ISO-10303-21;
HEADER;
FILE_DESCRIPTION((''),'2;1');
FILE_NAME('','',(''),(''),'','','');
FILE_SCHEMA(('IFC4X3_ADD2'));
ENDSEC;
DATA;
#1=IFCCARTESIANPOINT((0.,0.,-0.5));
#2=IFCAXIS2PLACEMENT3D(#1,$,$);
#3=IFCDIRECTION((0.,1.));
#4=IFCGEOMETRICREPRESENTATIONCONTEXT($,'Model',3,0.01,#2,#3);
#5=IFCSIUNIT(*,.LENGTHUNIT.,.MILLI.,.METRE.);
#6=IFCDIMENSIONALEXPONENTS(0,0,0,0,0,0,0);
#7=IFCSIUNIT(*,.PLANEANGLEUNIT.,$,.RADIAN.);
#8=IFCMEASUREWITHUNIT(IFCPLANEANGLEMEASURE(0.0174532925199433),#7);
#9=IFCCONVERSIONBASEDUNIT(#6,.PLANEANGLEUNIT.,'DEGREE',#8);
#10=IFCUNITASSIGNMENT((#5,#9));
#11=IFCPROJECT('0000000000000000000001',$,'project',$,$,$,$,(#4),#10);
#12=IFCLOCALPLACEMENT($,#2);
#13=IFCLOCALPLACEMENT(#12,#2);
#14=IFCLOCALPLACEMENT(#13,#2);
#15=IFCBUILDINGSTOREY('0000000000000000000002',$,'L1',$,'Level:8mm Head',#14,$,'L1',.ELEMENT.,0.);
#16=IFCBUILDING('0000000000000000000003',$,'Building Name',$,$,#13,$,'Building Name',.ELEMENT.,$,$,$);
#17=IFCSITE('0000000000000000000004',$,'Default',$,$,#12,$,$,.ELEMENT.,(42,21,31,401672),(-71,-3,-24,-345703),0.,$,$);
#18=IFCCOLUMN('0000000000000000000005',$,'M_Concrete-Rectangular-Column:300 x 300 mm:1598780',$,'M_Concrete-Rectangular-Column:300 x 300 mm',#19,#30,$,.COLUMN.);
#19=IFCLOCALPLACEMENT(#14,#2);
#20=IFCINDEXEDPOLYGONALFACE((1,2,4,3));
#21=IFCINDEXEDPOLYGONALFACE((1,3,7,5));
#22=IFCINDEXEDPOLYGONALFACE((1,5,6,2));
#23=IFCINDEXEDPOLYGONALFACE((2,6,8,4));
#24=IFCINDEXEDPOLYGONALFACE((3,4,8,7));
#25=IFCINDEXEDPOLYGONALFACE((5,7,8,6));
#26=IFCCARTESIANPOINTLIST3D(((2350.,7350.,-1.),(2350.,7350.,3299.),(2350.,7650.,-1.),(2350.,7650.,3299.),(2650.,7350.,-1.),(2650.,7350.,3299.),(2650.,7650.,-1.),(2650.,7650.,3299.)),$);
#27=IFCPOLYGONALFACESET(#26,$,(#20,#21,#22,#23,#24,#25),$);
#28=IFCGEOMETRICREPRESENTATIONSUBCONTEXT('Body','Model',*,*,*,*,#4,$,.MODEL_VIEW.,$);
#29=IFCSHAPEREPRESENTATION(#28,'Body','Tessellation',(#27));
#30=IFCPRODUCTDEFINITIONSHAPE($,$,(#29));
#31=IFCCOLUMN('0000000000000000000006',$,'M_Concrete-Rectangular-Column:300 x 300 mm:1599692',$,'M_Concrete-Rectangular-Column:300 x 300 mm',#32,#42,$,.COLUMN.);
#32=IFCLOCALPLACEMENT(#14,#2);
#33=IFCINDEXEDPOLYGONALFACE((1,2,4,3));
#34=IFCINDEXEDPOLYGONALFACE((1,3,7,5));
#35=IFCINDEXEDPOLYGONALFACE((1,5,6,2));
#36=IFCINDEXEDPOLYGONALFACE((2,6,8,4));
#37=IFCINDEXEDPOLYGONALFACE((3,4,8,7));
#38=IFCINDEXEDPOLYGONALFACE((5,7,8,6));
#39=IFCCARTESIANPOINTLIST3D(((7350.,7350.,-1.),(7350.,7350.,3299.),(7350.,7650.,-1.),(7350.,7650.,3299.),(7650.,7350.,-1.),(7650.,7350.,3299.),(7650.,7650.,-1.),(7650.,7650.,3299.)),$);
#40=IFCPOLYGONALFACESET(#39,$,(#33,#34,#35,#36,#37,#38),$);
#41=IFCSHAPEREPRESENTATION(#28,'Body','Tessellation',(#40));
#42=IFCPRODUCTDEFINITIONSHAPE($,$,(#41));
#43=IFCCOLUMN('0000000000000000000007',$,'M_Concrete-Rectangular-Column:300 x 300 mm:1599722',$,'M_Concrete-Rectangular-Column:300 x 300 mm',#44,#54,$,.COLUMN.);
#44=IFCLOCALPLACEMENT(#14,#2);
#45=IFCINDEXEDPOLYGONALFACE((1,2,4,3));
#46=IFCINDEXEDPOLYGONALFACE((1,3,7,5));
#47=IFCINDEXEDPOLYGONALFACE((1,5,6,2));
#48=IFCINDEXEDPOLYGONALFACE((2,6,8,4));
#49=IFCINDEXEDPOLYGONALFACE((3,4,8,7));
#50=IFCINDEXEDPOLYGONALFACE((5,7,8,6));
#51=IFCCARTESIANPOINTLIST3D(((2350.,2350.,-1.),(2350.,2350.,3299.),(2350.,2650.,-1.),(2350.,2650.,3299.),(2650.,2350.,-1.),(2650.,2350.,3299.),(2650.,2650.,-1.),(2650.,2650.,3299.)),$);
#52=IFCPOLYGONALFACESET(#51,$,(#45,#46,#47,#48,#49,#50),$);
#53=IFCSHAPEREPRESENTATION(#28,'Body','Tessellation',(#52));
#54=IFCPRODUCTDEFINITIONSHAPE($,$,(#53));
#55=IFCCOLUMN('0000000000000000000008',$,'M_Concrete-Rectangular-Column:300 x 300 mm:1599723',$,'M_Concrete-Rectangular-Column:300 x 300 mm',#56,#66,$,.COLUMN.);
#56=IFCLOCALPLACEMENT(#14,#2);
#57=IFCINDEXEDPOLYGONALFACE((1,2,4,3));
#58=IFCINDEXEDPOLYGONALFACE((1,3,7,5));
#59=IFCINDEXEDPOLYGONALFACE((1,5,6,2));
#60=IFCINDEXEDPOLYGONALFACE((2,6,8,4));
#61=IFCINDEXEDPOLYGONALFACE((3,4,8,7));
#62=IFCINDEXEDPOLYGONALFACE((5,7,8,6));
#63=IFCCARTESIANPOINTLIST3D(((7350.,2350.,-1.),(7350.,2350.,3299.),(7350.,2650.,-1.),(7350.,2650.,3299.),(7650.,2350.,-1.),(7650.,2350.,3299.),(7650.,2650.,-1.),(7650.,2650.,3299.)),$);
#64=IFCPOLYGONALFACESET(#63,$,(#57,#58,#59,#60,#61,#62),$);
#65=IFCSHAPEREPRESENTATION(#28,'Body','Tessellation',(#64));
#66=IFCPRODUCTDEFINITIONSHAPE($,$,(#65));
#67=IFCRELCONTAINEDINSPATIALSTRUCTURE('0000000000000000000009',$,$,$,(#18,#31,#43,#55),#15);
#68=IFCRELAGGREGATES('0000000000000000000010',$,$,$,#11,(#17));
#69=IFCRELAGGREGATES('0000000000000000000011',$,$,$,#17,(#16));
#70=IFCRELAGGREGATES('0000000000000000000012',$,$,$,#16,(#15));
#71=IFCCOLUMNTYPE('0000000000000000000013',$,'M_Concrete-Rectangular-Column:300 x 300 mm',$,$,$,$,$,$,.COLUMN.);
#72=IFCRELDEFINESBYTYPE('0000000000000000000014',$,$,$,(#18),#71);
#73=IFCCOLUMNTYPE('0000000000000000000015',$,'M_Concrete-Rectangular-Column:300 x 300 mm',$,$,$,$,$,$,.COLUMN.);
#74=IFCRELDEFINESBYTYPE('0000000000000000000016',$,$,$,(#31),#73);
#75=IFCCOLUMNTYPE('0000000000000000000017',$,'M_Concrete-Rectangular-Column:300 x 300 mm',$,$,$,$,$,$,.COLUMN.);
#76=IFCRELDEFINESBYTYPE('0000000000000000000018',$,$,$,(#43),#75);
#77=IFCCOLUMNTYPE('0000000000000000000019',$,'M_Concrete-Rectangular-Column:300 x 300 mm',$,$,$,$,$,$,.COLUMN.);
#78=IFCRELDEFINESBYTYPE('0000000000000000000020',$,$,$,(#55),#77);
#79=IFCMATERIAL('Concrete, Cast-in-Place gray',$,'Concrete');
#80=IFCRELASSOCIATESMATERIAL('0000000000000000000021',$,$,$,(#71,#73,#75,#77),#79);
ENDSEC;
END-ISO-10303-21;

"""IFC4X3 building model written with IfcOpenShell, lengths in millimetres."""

from ifc_helpers import new_model, entity, si_unit, converted_unit, direction, frame, origin_2d_with_axis, place, context, subcontext, project, spatial, rectangle, extrude, source, transform, mapped, material, material_profile, profile_set, type_object, type_shapes, element, save


model = new_model("IFC4X3")

# Units and contexts
model_context = context("Model", 3, precision=0.01, world=frame((0.0, 0.0, -0.5)), true_north=direction((0.0, 1.0)))
body_context = subcontext(model_context, "Body", "Model", "MODEL_VIEW")
ifc_project = project(units=[si_unit("LENGTHUNIT", "METRE", prefix="MILLI"), converted_unit("PLANEANGLEUNIT", "DEGREE", entity("IfcPlaneAngleMeasure", 0.0174532925199433), si_unit("PLANEANGLEUNIT", "RADIAN"), dimensions=[0, 0, 0, 0, 0, 0, 0])], contexts=[model_context])

# Site, building, storey
site_placement = place(None, frame((0.0, 0.0, -0.5)))
site = spatial("IfcSite", under=ifc_project, at=site_placement, Name="Default", CompositionType="ELEMENT", RefLatitude=(42, 21, 31, 401672), RefLongitude=(-71, -3, -24, -345703), RefElevation=0.0)
building_placement = place(site_placement, frame((0.0, 0.0, -0.5)))
building = spatial("IfcBuilding", under=site, at=building_placement, Name="Building Name", LongName="Building Name", CompositionType="ELEMENT")
storey_placement = place(building_placement, frame((0.0, 0.0, -0.5)))
storey = spatial("IfcBuildingStorey", under=building, at=storey_placement, Name="L1", ObjectType="Level:8mm Head", LongName="L1", CompositionType="ELEMENT", Elevation=0.0)

# Columns
ifc_material_1 = material(Name="Concrete, Cast-in-Place gray", Category="Concrete")
ifc_material_profile_1 = material_profile(ifc_material_1, rectangle(XDim=300.0, YDim=300.0, at=origin_2d_with_axis()), Name="300 x 300 mm")
ifc_profile_set_1 = profile_set([ifc_material_profile_1], Name="300 x 300 mm")
column_type_1 = type_object("IfcColumnType", Name="M_Concrete-Rectangular-Column:300 x 300 mm", PredefinedType="COLUMN", material=ifc_profile_set_1)
shared_shape_1 = source(frame((0.0, 0.0, -0.5)), body_context, "Body", "SweptSolid", [
    extrude(rectangle(XDim=300.0, YDim=300.0, at=origin_2d_with_axis()), frame((2500.0, 7500.0, 0.0)), (0.0, 0.0, 1.0), 3300.0),
])
type_shapes(column_type_1, [shared_shape_1])
column_1_placement = place(storey_placement, frame((0.0, 0.0, -0.5)))
element("IfcColumn", 1, at=column_1_placement, inside=storey, type_object=column_type_1, Name="M_Concrete-Rectangular-Column:300 x 300 mm:1598780", ObjectType="M_Concrete-Rectangular-Column:300 x 300 mm", PredefinedType="COLUMN", context=body_context, shape_type="MappedRepresentation", body=[
    mapped(shared_shape_1, transform((0.0, 0.0, -0.5), scale=1.0)),
])
column_type_2 = type_object("IfcColumnType", Name="M_Concrete-Rectangular-Column:300 x 300 mm", PredefinedType="COLUMN", material=ifc_profile_set_1)
shared_shape_2 = source(frame((0.0, 0.0, -0.5)), body_context, "Body", "SweptSolid", [
    extrude(rectangle(XDim=300.0, YDim=300.0, at=origin_2d_with_axis()), frame((7500.0, 7500.0, 0.0)), (0.0, 0.0, 1.0), 3300.0),
])
type_shapes(column_type_2, [shared_shape_2])
column_2_placement = place(storey_placement, frame((0.0, 0.0, -0.5)))
element("IfcColumn", 2, at=column_2_placement, inside=storey, type_object=column_type_2, Name="M_Concrete-Rectangular-Column:300 x 300 mm:1599692", ObjectType="M_Concrete-Rectangular-Column:300 x 300 mm", PredefinedType="COLUMN", context=body_context, shape_type="MappedRepresentation", body=[
    mapped(shared_shape_2, transform((0.0, 0.0, -0.5), scale=1.0)),
])
column_type_3 = type_object("IfcColumnType", Name="M_Concrete-Rectangular-Column:300 x 300 mm", PredefinedType="COLUMN", material=ifc_profile_set_1)
shared_shape_3 = source(frame((0.0, 0.0, -0.5)), body_context, "Body", "SweptSolid", [
    extrude(rectangle(XDim=300.0, YDim=300.0, at=origin_2d_with_axis()), frame((2500.0, 2500.0, 0.0)), (0.0, 0.0, 1.0), 3300.0),
])
type_shapes(column_type_3, [shared_shape_3])
column_3_placement = place(storey_placement, frame((0.0, 0.0, -0.5)))
element("IfcColumn", 3, at=column_3_placement, inside=storey, type_object=column_type_3, Name="M_Concrete-Rectangular-Column:300 x 300 mm:1599722", ObjectType="M_Concrete-Rectangular-Column:300 x 300 mm", PredefinedType="COLUMN", context=body_context, shape_type="MappedRepresentation", body=[
    mapped(shared_shape_3, transform((0.0, 0.0, -0.5), scale=1.0)),
])
column_type_4 = type_object("IfcColumnType", Name="M_Concrete-Rectangular-Column:300 x 300 mm", PredefinedType="COLUMN", material=ifc_profile_set_1)
shared_shape_4 = source(frame((0.0, 0.0, -0.5)), body_context, "Body", "SweptSolid", [
    extrude(rectangle(XDim=300.0, YDim=300.0, at=origin_2d_with_axis()), frame((7500.0, 2500.0, 0.0)), (0.0, 0.0, 1.0), 3300.0),
])
type_shapes(column_type_4, [shared_shape_4])
column_4_placement = place(storey_placement, frame((0.0, 0.0, -0.5)))
element("IfcColumn", 4, at=column_4_placement, inside=storey, type_object=column_type_4, Name="M_Concrete-Rectangular-Column:300 x 300 mm:1599723", ObjectType="M_Concrete-Rectangular-Column:300 x 300 mm", PredefinedType="COLUMN", context=body_context, shape_type="MappedRepresentation", body=[
    mapped(shared_shape_4, transform((0.0, 0.0, -0.5), scale=1.0)),
])

save(model, "model.ifc")
